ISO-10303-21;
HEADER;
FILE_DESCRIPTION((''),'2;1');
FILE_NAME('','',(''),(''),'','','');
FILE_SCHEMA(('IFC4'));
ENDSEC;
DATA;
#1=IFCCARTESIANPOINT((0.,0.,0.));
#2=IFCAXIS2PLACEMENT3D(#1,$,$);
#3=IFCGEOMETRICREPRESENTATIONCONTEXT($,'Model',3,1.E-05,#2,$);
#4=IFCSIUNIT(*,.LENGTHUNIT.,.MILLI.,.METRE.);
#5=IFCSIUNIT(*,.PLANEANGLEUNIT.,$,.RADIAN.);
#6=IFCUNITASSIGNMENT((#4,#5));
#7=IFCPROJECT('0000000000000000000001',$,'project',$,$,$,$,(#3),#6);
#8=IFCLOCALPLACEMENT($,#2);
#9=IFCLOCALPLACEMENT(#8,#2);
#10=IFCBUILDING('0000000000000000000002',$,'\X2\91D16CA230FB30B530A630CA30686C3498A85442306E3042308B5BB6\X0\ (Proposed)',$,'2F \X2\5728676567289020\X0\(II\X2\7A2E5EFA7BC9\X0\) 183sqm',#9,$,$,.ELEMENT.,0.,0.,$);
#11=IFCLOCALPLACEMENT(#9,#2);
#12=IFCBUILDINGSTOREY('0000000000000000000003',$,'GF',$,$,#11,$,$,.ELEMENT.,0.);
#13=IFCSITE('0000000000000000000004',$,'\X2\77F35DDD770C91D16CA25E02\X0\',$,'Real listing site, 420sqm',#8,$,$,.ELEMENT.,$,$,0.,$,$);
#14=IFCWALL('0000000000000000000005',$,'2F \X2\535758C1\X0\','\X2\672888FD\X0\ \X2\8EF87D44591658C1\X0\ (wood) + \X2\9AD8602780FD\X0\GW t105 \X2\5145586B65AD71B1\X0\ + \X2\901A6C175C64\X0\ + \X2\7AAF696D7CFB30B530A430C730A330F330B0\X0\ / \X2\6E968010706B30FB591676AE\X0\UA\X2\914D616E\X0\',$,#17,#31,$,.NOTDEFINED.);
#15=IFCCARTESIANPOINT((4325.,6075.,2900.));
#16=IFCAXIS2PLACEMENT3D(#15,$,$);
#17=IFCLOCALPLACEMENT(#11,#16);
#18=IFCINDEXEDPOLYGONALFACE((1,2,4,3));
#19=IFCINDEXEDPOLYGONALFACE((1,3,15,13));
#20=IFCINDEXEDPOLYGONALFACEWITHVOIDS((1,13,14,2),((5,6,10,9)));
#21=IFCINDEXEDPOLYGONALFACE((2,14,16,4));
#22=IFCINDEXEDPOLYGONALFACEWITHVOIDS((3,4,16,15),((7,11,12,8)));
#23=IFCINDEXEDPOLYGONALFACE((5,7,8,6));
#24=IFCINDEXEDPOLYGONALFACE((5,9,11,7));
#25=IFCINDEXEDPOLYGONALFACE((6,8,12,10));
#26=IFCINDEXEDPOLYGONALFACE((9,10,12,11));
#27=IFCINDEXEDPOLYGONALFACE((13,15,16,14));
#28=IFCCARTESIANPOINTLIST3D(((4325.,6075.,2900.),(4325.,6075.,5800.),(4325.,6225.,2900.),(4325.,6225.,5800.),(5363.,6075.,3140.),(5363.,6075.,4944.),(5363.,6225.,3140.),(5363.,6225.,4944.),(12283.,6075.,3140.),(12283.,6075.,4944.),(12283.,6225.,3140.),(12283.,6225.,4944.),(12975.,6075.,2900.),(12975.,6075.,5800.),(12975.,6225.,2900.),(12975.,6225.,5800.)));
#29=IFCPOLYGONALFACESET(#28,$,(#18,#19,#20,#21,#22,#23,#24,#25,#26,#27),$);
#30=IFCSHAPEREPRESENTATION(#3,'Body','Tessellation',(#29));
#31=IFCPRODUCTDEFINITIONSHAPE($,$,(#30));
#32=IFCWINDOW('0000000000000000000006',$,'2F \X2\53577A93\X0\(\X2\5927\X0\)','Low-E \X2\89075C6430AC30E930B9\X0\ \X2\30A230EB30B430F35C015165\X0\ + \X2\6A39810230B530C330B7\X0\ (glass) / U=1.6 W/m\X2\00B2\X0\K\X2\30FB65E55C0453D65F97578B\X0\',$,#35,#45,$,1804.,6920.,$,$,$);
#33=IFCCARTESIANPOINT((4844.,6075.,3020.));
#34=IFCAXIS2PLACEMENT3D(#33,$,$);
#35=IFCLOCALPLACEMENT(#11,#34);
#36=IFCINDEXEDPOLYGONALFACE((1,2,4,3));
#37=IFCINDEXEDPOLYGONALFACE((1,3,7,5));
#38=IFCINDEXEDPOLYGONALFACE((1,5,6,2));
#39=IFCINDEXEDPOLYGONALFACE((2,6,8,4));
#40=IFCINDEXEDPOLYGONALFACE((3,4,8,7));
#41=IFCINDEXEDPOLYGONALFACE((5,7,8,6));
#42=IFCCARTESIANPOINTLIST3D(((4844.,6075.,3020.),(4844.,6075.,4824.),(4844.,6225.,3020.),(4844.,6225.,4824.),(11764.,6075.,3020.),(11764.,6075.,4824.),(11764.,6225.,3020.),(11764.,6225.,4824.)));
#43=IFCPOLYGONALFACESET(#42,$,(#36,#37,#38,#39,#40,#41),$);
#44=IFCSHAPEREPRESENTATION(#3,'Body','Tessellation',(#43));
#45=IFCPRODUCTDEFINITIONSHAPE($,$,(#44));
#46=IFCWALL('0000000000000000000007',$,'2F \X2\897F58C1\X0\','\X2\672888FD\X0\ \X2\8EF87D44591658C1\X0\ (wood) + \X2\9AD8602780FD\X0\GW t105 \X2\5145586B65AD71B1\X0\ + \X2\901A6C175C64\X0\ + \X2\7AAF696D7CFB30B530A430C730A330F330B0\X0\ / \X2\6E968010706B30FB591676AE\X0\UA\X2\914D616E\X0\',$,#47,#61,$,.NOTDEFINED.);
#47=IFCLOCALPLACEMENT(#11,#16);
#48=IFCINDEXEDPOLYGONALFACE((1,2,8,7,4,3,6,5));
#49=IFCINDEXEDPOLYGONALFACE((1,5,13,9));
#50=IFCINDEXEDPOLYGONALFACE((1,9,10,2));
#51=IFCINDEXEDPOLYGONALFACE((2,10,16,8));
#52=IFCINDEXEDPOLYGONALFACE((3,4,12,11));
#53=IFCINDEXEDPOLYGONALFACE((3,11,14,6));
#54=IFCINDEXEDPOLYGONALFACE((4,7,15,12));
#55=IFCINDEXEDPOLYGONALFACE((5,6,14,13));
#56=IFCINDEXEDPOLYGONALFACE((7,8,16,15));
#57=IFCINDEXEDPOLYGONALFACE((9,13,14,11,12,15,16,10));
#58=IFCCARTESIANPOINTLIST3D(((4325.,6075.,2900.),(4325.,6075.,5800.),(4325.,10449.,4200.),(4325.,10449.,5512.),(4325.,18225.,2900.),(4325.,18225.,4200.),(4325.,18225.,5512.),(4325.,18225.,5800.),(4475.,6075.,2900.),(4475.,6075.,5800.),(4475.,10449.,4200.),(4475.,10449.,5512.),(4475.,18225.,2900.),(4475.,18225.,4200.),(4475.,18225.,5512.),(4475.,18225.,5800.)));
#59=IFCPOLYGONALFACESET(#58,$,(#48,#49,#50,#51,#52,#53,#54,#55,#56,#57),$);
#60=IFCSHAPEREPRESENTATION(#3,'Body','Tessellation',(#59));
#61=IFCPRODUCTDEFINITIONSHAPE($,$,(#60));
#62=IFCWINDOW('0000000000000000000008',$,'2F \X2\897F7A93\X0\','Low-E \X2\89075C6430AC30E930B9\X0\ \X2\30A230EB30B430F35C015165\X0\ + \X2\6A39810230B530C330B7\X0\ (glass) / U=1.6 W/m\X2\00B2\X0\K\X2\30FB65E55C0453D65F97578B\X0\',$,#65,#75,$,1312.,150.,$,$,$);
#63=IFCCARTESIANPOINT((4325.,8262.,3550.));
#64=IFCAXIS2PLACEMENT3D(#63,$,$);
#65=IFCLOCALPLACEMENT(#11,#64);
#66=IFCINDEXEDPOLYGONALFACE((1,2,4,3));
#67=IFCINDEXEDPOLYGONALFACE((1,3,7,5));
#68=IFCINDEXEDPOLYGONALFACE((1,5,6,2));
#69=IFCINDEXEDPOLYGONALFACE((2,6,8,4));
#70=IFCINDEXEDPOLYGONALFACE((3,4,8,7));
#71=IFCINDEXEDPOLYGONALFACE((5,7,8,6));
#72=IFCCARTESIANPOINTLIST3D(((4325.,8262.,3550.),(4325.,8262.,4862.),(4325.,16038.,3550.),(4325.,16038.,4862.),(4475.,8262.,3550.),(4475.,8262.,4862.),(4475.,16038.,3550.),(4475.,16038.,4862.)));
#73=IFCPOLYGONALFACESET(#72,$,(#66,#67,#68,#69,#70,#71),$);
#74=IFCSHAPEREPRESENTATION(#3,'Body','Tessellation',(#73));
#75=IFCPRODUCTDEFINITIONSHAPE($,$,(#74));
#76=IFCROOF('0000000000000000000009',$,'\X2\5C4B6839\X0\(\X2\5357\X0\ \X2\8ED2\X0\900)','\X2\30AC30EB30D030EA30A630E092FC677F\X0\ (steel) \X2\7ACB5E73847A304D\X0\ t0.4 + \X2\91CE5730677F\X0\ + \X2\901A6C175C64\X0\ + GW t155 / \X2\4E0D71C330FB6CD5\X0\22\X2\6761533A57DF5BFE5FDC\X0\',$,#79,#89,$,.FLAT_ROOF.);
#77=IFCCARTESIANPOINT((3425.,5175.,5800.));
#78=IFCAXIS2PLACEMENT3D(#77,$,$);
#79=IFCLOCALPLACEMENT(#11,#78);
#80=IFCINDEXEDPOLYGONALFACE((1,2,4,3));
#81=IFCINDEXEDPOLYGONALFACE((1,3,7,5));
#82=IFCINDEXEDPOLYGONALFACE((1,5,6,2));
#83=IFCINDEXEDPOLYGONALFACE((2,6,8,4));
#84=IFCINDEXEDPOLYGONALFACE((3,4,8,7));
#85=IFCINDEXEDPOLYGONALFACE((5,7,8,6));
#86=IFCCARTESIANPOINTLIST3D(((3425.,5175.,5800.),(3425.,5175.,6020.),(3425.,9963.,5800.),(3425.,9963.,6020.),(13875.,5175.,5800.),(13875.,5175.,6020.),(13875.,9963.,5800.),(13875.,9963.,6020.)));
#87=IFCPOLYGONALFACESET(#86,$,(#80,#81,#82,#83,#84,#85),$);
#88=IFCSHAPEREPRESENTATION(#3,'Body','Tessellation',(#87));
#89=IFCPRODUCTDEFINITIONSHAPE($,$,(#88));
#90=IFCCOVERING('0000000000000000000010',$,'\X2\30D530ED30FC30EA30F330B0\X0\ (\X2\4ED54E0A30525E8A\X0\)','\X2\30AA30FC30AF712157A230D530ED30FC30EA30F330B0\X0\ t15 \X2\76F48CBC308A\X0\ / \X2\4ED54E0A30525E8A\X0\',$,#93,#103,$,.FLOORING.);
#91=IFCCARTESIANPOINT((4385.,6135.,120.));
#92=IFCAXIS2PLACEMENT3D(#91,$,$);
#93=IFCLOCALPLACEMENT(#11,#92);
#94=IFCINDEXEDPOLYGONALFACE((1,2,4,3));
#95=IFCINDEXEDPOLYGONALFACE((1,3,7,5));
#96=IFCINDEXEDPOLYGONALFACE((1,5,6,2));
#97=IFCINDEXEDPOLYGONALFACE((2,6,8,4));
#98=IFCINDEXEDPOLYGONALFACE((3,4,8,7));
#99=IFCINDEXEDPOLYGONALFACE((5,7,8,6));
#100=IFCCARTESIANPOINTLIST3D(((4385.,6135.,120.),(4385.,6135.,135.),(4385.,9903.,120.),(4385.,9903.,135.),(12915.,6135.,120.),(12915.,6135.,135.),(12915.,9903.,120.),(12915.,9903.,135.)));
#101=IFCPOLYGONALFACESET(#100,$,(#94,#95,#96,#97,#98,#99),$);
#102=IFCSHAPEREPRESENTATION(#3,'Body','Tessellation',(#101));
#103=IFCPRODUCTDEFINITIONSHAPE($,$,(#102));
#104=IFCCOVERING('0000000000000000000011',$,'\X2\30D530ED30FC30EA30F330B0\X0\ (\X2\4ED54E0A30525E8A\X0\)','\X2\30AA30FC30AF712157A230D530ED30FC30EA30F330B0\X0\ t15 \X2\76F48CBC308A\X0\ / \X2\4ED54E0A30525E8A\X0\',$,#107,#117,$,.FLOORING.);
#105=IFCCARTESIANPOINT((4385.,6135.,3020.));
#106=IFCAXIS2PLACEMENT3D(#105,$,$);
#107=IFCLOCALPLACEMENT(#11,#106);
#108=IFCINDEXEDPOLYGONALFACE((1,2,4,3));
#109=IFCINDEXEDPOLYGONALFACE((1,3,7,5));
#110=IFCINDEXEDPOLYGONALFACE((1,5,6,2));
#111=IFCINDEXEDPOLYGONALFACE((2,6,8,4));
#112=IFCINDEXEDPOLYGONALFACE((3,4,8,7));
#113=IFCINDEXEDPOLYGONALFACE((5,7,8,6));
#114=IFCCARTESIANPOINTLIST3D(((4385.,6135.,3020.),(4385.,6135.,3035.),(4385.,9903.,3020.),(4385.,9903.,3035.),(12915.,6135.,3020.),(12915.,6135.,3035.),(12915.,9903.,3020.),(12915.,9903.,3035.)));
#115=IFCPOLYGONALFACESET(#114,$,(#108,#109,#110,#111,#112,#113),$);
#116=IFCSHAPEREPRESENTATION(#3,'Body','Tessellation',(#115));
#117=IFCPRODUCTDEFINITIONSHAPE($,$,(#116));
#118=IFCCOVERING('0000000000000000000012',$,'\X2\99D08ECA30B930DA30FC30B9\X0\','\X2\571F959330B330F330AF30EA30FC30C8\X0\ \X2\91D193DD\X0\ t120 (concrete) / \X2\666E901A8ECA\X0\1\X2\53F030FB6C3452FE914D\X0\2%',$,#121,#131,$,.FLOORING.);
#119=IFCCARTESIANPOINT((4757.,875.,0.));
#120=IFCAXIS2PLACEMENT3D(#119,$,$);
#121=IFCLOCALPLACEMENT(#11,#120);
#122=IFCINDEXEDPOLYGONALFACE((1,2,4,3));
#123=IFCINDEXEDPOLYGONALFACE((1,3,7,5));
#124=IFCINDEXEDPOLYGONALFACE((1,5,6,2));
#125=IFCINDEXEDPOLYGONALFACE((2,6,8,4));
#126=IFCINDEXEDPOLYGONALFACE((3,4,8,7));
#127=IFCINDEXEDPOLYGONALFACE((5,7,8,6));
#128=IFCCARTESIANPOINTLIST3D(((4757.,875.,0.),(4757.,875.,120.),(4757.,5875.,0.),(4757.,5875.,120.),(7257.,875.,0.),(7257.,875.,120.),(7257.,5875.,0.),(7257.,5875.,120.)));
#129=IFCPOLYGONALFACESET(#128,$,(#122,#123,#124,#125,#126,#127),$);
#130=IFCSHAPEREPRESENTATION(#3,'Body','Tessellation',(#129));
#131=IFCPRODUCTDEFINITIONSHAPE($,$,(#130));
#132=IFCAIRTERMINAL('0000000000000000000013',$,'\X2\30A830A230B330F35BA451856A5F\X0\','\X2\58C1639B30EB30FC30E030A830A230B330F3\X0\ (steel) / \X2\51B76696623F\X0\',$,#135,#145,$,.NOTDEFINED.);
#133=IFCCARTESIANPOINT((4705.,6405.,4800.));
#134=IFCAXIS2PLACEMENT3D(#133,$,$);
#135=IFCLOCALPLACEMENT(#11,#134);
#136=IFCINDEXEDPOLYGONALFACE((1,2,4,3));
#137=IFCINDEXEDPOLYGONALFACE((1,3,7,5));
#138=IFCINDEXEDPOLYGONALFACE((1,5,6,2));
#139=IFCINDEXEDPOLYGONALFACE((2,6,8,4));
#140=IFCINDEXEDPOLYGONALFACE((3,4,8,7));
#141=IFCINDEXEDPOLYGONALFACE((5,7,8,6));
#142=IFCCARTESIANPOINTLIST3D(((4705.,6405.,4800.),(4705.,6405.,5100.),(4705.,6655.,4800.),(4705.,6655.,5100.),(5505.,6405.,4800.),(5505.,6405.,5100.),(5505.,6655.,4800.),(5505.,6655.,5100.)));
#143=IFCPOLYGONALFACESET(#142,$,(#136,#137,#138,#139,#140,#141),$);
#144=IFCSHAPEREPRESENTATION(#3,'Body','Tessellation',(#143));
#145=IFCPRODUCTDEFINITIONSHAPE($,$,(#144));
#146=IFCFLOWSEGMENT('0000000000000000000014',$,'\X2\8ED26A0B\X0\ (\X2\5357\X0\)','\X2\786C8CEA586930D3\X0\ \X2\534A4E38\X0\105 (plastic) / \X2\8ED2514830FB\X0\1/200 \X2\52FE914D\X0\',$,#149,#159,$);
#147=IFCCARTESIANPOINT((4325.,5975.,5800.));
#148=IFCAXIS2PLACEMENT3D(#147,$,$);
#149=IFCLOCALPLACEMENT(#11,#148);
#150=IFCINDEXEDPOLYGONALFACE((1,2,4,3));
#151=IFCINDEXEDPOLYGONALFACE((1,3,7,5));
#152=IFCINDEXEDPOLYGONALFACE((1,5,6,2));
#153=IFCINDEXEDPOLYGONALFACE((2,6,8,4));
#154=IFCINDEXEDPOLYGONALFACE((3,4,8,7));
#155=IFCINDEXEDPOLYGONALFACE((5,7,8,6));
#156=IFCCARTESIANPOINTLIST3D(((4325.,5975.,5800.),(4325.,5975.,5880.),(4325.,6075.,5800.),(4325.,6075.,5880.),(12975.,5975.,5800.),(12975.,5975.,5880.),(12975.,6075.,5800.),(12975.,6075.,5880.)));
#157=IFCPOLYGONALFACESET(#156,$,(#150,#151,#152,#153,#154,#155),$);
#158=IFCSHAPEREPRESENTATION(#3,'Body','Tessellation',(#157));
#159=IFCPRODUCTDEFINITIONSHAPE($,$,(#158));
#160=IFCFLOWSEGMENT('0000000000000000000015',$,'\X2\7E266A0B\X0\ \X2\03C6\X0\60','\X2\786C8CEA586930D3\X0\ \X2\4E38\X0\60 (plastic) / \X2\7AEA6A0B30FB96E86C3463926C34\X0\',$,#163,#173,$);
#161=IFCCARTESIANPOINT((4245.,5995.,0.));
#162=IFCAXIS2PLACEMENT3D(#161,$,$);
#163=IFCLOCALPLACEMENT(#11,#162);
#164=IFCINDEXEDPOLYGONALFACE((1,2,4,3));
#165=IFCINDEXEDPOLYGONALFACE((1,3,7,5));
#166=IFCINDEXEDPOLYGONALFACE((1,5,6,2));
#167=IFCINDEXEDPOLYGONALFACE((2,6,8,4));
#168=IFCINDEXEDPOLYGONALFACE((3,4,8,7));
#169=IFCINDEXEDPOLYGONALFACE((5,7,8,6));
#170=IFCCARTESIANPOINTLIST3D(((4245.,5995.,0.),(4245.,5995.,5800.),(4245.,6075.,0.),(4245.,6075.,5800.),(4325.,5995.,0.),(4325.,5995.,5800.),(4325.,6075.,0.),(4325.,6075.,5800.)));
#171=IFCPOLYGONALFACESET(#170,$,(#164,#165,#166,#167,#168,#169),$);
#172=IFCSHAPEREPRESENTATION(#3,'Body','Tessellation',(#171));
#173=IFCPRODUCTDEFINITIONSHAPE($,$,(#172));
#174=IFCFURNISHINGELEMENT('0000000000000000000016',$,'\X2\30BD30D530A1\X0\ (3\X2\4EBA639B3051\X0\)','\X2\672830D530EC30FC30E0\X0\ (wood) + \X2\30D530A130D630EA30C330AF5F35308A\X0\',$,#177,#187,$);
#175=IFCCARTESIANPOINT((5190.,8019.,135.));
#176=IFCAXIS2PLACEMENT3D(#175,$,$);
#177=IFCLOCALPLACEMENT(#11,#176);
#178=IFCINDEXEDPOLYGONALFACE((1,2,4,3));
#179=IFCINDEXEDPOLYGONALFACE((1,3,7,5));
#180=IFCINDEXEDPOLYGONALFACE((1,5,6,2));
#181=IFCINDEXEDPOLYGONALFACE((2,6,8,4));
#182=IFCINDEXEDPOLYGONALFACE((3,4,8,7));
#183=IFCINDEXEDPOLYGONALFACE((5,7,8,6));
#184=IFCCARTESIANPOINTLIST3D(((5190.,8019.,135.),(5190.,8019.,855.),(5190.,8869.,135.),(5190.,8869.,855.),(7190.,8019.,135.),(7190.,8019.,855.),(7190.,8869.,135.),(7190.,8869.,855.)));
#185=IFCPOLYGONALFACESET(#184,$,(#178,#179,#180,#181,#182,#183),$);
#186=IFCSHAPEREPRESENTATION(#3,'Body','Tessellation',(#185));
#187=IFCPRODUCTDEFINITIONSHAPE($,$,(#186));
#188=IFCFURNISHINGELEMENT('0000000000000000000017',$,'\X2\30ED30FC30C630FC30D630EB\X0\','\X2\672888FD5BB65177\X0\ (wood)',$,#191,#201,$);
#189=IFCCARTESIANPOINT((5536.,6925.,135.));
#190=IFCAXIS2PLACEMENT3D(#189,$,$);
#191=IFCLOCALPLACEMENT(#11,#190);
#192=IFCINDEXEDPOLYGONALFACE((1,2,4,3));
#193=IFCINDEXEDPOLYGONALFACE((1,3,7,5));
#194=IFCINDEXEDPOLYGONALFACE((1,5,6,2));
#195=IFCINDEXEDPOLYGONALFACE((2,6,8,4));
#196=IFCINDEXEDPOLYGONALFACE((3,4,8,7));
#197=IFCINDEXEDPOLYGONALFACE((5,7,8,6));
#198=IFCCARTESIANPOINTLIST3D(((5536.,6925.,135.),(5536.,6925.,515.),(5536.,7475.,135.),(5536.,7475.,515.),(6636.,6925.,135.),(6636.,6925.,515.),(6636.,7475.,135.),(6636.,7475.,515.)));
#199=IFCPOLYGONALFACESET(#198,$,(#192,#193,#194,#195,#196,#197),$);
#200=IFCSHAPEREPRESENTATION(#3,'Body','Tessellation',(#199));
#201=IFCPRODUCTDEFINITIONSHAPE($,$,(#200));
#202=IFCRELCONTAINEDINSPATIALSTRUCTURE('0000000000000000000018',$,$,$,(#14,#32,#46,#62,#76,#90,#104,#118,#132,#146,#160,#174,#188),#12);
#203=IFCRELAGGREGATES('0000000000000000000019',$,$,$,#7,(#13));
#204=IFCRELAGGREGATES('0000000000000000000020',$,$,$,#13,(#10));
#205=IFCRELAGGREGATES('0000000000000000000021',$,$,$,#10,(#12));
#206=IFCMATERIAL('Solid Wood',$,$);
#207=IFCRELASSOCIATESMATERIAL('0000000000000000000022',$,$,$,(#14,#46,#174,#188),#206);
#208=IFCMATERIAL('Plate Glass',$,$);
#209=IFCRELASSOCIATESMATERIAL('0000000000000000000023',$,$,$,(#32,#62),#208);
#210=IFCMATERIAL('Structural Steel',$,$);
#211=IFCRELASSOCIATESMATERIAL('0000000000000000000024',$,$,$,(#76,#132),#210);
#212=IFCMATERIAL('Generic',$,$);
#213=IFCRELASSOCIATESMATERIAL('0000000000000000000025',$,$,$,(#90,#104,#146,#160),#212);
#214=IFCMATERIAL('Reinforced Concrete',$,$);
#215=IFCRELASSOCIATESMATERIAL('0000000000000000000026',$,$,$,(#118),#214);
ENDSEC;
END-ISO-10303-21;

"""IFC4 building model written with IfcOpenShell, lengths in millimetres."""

from ifc_helpers import new_model, si_unit, frame, frame_2d, origin, place, context, project, spatial, rectangle, extrude, material, element, fill, save


model = new_model("IFC4")

# Units and contexts
model_context = context("Model", 3, precision=1e-05, world=origin())
ifc_project = project(units=[si_unit("LENGTHUNIT", "METRE", prefix="MILLI"), si_unit("PLANEANGLEUNIT", "RADIAN")], contexts=[model_context])

# Site, building, storey
site_placement = place(None, origin())
site = spatial("IfcSite", under=ifc_project, at=site_placement, Name="石川県金沢市", ObjectType="Real listing site, 420sqm", CompositionType="ELEMENT", RefElevation=0.0)
building_placement = place(site_placement, origin())
building = spatial("IfcBuilding", under=site, at=building_placement, Name="金沢・サウナと水風呂のある家 (Proposed)", ObjectType="2F 在来木造(II種建築) 183sqm", CompositionType="ELEMENT", ElevationOfRefHeight=0.0, ElevationOfTerrain=0.0)
storey_placement = place(building_placement, origin())
storey = spatial("IfcBuildingStorey", under=building, at=storey_placement, Name="GF", CompositionType="ELEMENT", Elevation=0.0)

# Shared definitions
ifc_material_1 = material(Name="Solid Wood")

# Shared definitions
ifc_material_2 = material(Name="Reinforced Concrete")

# Shared definitions
ifc_material_3 = material(Name="Plate Glass")

# Walls, openings, windows
wall_1_placement = place(storey_placement, frame((4325.0, 6075.0, 2900.0)))
wall_1 = element("IfcWall", 1, at=wall_1_placement, inside=storey, material=ifc_material_1, Name="2F 南壁", Description="木製 軸組外壁 (wood) + 高性能GW t105 充填断熱 + 通気層 + 窯業系サイディング / 準耐火・外皮UA配慮", PredefinedType="NOTDEFINED", context=model_context, shape_type="SweptSolid", body=[
    extrude(rectangle(XDim=8650.0, YDim=150.0, at=frame_2d((4325.0, 75.0))), frame((4325.0, 6075.0, 2900.0)), (0.0, 0.0, 1.0), 2900.0),
])
opening_1_placement = place(storey_placement, frame((4844.0, 6075.0, 3020.0)))
opening_1 = element("IfcOpeningElement", 2, at=opening_1_placement, cuts=wall_1, PredefinedType="NOTDEFINED", context=model_context, shape_type="SweptSolid", body=[
    extrude(rectangle(XDim=6920.0, YDim=150.0, at=frame_2d((3460.0, 75.0))), frame((4844.0, 6075.0, 3020.0)), (0.0, 0.0, 1.0), 1804.0),
])
window_1_placement = place(storey_placement, frame((4844.0, 6075.0, 3020.0)))
window_1 = element("IfcWindow", 3, at=window_1_placement, inside=storey, material=ifc_material_3, Name="2F 南窓(大)", Description="Low-E 複層ガラス アルゴン封入 + 樹脂サッシ (glass) / U=1.6 W/m²K・日射取得型", OverallHeight=1804.0, OverallWidth=6920.0, context=model_context, shape_type="SweptSolid", body=[
    extrude(rectangle(XDim=6920.0, YDim=150.0, at=frame_2d((3460.0, 75.0))), frame((4844.0, 6075.0, 3020.0)), (0.0, 0.0, 1.0), 1804.0),
])
fill(opening_1, window_1)
wall_2_placement = place(storey_placement, frame((4325.0, 6075.0, 2900.0)))
wall_2 = element("IfcWall", 4, at=wall_2_placement, inside=storey, material=ifc_material_1, Name="2F 西壁", Description="木製 軸組外壁 (wood) + 高性能GW t105 充填断熱 + 通気層 + 窯業系サイディング / 準耐火・外皮UA配慮", PredefinedType="NOTDEFINED", context=model_context, shape_type="SweptSolid", body=[
    extrude(rectangle(XDim=150.0, YDim=12150.0, at=frame_2d((75.0, 6075.0))), frame((4325.0, 6075.0, 2900.0)), (0.0, 0.0, 1.0), 2900.0),
])
opening_2_placement = place(storey_placement, frame((4325.0, 8262.0, 3550.0)))
opening_2 = element("IfcOpeningElement", 5, at=opening_2_placement, cuts=wall_2, PredefinedType="NOTDEFINED", context=model_context, shape_type="SweptSolid", body=[
    extrude(rectangle(XDim=150.0, YDim=7776.0, at=frame_2d((75.0, 3888.0))), frame((4325.0, 8262.0, 3550.0)), (0.0, 0.0, 1.0), 1312.0),
])
window_2_placement = place(storey_placement, frame((4325.0, 8262.0, 3550.0)))
window_2 = element("IfcWindow", 6, at=window_2_placement, inside=storey, material=ifc_material_3, Name="2F 西窓", Description="Low-E 複層ガラス アルゴン封入 + 樹脂サッシ (glass) / U=1.6 W/m²K・日射取得型", OverallHeight=1312.0, OverallWidth=150.0, context=model_context, shape_type="SweptSolid", body=[
    extrude(rectangle(XDim=150.0, YDim=7776.0, at=frame_2d((75.0, 3888.0))), frame((4325.0, 8262.0, 3550.0)), (0.0, 0.0, 1.0), 1312.0),
])
fill(opening_2, window_2)

# Roof
ifc_material_4 = material(Name="Structural Steel")
for number, where, name in (
    (7, (3425.0, 5175.0, 5800.0), "屋根(南 軒900)"),
):
    element("IfcRoof", number, at=place(storey_placement, frame(where)), inside=storey, material=ifc_material_4, Name=name, Description="ガルバリウム鋼板 (steel) 立平葺き t0.4 + 野地板 + 通気層 + GW t155 / 不燃・法22条区域対応", PredefinedType="FLAT_ROOF", context=model_context, shape_type="SweptSolid", body=[
        extrude(rectangle(XDim=10450.0, YDim=4788.0, at=frame_2d((5225.0, 2394.0))), frame((3425.0, 5175.0, 5800.0)), (0.0, 0.0, 1.0), 220.0),
    ])

# Coverings
ifc_material_5 = material(Name="Generic")
covering_1_placement = place(storey_placement, frame((4385.0, 6135.0, 120.0)))
element("IfcCovering", 8, at=covering_1_placement, inside=storey, material=ifc_material_5, Name="フローリング (仕上げ床)", Description="オーク無垢フローリング t15 直貼り / 仕上げ床", PredefinedType="FLOORING", context=model_context, shape_type="SweptSolid", body=[
    extrude(rectangle(XDim=8530.0, YDim=3768.0, at=frame_2d((4265.0, 1884.0))), frame((4385.0, 6135.0, 120.0)), (0.0, 0.0, 1.0), 15.0),
])
covering_2_placement = place(storey_placement, frame((4385.0, 6135.0, 3020.0)))
element("IfcCovering", 9, at=covering_2_placement, inside=storey, material=ifc_material_5, Name="フローリング (仕上げ床)", Description="オーク無垢フローリング t15 直貼り / 仕上げ床", PredefinedType="FLOORING", context=model_context, shape_type="SweptSolid", body=[
    extrude(rectangle(XDim=8530.0, YDim=3768.0, at=frame_2d((4265.0, 1884.0))), frame((4385.0, 6135.0, 3020.0)), (0.0, 0.0, 1.0), 15.0),
])
covering_3_placement = place(storey_placement, frame((4757.0, 875.0, 0.0)))
element("IfcCovering", 10, at=covering_3_placement, inside=storey, material=ifc_material_2, Name="駐車スペース", Description="土間コンクリート 金鏝 t120 (concrete) / 普通車1台・水勾配2%", PredefinedType="FLOORING", context=model_context, shape_type="SweptSolid", body=[
    extrude(rectangle(XDim=2500.0, YDim=5000.0, at=frame_2d((1250.0, 2500.0))), frame((4757.0, 875.0, 0.0)), (0.0, 0.0, 1.0), 120.0),
])

# Air terminal
air_terminal_placement = place(storey_placement, frame((4705.0, 6405.0, 4800.0)))
element("IfcAirTerminal", 11, at=air_terminal_placement, inside=storey, material=ifc_material_4, Name="エアコン室内機", Description="壁掛ルームエアコン (steel) / 冷暖房", PredefinedType="NOTDEFINED", context=model_context, shape_type="SweptSolid", body=[
    extrude(rectangle(XDim=800.0, YDim=250.0, at=frame_2d((400.0, 125.0))), frame((4705.0, 6405.0, 4800.0)), (0.0, 0.0, 1.0), 300.0),
])

# Flow segments
flow_segment_1_placement = place(storey_placement, frame((4325.0, 5975.0, 5800.0)))
element("IfcFlowSegment", 12, at=flow_segment_1_placement, inside=storey, material=ifc_material_5, Name="軒樋 (南)", Description="硬質塩ビ 半丸105 (plastic) / 軒先・1/200 勾配", context=model_context, shape_type="SweptSolid", body=[
    extrude(rectangle(XDim=8650.0, YDim=100.0, at=frame_2d((4325.0, 50.0))), frame((4325.0, 5975.0, 5800.0)), (0.0, 0.0, 1.0), 80.0),
])
flow_segment_2_placement = place(storey_placement, frame((4245.0, 5995.0, 0.0)))
element("IfcFlowSegment", 13, at=flow_segment_2_placement, inside=storey, material=ifc_material_5, Name="縦樋 φ60", Description="硬質塩ビ 丸60 (plastic) / 竪樋・雨水排水", context=model_context, shape_type="SweptSolid", body=[
    extrude(rectangle(XDim=80.0, YDim=80.0, at=frame_2d((40.0, 40.0))), frame((4245.0, 5995.0, 0.0)), (0.0, 0.0, 1.0), 5800.0),
])

# Furnishing elements
furnishing_1_placement = place(storey_placement, frame((5190.0, 8019.0, 135.0)))
element("IfcFurnishingElement", 14, at=furnishing_1_placement, inside=storey, material=ifc_material_1, Name="ソファ (3人掛け)", Description="木フレーム (wood) + ファブリック張り", context=model_context, shape_type="SweptSolid", body=[
    extrude(rectangle(XDim=2000.0, YDim=850.0, at=frame_2d((1000.0, 425.0))), frame((5190.0, 8019.0, 135.0)), (0.0, 0.0, 1.0), 720.0),
])
furnishing_2_placement = place(storey_placement, frame((5536.0, 6925.0, 135.0)))
element("IfcFurnishingElement", 15, at=furnishing_2_placement, inside=storey, material=ifc_material_1, Name="ローテーブル", Description="木製家具 (wood)", context=model_context, shape_type="SweptSolid", body=[
    extrude(rectangle(XDim=1100.0, YDim=550.0, at=frame_2d((550.0, 275.0))), frame((5536.0, 6925.0, 135.0)), (0.0, 0.0, 1.0), 380.0),
])

save(model, "model.ifc")
